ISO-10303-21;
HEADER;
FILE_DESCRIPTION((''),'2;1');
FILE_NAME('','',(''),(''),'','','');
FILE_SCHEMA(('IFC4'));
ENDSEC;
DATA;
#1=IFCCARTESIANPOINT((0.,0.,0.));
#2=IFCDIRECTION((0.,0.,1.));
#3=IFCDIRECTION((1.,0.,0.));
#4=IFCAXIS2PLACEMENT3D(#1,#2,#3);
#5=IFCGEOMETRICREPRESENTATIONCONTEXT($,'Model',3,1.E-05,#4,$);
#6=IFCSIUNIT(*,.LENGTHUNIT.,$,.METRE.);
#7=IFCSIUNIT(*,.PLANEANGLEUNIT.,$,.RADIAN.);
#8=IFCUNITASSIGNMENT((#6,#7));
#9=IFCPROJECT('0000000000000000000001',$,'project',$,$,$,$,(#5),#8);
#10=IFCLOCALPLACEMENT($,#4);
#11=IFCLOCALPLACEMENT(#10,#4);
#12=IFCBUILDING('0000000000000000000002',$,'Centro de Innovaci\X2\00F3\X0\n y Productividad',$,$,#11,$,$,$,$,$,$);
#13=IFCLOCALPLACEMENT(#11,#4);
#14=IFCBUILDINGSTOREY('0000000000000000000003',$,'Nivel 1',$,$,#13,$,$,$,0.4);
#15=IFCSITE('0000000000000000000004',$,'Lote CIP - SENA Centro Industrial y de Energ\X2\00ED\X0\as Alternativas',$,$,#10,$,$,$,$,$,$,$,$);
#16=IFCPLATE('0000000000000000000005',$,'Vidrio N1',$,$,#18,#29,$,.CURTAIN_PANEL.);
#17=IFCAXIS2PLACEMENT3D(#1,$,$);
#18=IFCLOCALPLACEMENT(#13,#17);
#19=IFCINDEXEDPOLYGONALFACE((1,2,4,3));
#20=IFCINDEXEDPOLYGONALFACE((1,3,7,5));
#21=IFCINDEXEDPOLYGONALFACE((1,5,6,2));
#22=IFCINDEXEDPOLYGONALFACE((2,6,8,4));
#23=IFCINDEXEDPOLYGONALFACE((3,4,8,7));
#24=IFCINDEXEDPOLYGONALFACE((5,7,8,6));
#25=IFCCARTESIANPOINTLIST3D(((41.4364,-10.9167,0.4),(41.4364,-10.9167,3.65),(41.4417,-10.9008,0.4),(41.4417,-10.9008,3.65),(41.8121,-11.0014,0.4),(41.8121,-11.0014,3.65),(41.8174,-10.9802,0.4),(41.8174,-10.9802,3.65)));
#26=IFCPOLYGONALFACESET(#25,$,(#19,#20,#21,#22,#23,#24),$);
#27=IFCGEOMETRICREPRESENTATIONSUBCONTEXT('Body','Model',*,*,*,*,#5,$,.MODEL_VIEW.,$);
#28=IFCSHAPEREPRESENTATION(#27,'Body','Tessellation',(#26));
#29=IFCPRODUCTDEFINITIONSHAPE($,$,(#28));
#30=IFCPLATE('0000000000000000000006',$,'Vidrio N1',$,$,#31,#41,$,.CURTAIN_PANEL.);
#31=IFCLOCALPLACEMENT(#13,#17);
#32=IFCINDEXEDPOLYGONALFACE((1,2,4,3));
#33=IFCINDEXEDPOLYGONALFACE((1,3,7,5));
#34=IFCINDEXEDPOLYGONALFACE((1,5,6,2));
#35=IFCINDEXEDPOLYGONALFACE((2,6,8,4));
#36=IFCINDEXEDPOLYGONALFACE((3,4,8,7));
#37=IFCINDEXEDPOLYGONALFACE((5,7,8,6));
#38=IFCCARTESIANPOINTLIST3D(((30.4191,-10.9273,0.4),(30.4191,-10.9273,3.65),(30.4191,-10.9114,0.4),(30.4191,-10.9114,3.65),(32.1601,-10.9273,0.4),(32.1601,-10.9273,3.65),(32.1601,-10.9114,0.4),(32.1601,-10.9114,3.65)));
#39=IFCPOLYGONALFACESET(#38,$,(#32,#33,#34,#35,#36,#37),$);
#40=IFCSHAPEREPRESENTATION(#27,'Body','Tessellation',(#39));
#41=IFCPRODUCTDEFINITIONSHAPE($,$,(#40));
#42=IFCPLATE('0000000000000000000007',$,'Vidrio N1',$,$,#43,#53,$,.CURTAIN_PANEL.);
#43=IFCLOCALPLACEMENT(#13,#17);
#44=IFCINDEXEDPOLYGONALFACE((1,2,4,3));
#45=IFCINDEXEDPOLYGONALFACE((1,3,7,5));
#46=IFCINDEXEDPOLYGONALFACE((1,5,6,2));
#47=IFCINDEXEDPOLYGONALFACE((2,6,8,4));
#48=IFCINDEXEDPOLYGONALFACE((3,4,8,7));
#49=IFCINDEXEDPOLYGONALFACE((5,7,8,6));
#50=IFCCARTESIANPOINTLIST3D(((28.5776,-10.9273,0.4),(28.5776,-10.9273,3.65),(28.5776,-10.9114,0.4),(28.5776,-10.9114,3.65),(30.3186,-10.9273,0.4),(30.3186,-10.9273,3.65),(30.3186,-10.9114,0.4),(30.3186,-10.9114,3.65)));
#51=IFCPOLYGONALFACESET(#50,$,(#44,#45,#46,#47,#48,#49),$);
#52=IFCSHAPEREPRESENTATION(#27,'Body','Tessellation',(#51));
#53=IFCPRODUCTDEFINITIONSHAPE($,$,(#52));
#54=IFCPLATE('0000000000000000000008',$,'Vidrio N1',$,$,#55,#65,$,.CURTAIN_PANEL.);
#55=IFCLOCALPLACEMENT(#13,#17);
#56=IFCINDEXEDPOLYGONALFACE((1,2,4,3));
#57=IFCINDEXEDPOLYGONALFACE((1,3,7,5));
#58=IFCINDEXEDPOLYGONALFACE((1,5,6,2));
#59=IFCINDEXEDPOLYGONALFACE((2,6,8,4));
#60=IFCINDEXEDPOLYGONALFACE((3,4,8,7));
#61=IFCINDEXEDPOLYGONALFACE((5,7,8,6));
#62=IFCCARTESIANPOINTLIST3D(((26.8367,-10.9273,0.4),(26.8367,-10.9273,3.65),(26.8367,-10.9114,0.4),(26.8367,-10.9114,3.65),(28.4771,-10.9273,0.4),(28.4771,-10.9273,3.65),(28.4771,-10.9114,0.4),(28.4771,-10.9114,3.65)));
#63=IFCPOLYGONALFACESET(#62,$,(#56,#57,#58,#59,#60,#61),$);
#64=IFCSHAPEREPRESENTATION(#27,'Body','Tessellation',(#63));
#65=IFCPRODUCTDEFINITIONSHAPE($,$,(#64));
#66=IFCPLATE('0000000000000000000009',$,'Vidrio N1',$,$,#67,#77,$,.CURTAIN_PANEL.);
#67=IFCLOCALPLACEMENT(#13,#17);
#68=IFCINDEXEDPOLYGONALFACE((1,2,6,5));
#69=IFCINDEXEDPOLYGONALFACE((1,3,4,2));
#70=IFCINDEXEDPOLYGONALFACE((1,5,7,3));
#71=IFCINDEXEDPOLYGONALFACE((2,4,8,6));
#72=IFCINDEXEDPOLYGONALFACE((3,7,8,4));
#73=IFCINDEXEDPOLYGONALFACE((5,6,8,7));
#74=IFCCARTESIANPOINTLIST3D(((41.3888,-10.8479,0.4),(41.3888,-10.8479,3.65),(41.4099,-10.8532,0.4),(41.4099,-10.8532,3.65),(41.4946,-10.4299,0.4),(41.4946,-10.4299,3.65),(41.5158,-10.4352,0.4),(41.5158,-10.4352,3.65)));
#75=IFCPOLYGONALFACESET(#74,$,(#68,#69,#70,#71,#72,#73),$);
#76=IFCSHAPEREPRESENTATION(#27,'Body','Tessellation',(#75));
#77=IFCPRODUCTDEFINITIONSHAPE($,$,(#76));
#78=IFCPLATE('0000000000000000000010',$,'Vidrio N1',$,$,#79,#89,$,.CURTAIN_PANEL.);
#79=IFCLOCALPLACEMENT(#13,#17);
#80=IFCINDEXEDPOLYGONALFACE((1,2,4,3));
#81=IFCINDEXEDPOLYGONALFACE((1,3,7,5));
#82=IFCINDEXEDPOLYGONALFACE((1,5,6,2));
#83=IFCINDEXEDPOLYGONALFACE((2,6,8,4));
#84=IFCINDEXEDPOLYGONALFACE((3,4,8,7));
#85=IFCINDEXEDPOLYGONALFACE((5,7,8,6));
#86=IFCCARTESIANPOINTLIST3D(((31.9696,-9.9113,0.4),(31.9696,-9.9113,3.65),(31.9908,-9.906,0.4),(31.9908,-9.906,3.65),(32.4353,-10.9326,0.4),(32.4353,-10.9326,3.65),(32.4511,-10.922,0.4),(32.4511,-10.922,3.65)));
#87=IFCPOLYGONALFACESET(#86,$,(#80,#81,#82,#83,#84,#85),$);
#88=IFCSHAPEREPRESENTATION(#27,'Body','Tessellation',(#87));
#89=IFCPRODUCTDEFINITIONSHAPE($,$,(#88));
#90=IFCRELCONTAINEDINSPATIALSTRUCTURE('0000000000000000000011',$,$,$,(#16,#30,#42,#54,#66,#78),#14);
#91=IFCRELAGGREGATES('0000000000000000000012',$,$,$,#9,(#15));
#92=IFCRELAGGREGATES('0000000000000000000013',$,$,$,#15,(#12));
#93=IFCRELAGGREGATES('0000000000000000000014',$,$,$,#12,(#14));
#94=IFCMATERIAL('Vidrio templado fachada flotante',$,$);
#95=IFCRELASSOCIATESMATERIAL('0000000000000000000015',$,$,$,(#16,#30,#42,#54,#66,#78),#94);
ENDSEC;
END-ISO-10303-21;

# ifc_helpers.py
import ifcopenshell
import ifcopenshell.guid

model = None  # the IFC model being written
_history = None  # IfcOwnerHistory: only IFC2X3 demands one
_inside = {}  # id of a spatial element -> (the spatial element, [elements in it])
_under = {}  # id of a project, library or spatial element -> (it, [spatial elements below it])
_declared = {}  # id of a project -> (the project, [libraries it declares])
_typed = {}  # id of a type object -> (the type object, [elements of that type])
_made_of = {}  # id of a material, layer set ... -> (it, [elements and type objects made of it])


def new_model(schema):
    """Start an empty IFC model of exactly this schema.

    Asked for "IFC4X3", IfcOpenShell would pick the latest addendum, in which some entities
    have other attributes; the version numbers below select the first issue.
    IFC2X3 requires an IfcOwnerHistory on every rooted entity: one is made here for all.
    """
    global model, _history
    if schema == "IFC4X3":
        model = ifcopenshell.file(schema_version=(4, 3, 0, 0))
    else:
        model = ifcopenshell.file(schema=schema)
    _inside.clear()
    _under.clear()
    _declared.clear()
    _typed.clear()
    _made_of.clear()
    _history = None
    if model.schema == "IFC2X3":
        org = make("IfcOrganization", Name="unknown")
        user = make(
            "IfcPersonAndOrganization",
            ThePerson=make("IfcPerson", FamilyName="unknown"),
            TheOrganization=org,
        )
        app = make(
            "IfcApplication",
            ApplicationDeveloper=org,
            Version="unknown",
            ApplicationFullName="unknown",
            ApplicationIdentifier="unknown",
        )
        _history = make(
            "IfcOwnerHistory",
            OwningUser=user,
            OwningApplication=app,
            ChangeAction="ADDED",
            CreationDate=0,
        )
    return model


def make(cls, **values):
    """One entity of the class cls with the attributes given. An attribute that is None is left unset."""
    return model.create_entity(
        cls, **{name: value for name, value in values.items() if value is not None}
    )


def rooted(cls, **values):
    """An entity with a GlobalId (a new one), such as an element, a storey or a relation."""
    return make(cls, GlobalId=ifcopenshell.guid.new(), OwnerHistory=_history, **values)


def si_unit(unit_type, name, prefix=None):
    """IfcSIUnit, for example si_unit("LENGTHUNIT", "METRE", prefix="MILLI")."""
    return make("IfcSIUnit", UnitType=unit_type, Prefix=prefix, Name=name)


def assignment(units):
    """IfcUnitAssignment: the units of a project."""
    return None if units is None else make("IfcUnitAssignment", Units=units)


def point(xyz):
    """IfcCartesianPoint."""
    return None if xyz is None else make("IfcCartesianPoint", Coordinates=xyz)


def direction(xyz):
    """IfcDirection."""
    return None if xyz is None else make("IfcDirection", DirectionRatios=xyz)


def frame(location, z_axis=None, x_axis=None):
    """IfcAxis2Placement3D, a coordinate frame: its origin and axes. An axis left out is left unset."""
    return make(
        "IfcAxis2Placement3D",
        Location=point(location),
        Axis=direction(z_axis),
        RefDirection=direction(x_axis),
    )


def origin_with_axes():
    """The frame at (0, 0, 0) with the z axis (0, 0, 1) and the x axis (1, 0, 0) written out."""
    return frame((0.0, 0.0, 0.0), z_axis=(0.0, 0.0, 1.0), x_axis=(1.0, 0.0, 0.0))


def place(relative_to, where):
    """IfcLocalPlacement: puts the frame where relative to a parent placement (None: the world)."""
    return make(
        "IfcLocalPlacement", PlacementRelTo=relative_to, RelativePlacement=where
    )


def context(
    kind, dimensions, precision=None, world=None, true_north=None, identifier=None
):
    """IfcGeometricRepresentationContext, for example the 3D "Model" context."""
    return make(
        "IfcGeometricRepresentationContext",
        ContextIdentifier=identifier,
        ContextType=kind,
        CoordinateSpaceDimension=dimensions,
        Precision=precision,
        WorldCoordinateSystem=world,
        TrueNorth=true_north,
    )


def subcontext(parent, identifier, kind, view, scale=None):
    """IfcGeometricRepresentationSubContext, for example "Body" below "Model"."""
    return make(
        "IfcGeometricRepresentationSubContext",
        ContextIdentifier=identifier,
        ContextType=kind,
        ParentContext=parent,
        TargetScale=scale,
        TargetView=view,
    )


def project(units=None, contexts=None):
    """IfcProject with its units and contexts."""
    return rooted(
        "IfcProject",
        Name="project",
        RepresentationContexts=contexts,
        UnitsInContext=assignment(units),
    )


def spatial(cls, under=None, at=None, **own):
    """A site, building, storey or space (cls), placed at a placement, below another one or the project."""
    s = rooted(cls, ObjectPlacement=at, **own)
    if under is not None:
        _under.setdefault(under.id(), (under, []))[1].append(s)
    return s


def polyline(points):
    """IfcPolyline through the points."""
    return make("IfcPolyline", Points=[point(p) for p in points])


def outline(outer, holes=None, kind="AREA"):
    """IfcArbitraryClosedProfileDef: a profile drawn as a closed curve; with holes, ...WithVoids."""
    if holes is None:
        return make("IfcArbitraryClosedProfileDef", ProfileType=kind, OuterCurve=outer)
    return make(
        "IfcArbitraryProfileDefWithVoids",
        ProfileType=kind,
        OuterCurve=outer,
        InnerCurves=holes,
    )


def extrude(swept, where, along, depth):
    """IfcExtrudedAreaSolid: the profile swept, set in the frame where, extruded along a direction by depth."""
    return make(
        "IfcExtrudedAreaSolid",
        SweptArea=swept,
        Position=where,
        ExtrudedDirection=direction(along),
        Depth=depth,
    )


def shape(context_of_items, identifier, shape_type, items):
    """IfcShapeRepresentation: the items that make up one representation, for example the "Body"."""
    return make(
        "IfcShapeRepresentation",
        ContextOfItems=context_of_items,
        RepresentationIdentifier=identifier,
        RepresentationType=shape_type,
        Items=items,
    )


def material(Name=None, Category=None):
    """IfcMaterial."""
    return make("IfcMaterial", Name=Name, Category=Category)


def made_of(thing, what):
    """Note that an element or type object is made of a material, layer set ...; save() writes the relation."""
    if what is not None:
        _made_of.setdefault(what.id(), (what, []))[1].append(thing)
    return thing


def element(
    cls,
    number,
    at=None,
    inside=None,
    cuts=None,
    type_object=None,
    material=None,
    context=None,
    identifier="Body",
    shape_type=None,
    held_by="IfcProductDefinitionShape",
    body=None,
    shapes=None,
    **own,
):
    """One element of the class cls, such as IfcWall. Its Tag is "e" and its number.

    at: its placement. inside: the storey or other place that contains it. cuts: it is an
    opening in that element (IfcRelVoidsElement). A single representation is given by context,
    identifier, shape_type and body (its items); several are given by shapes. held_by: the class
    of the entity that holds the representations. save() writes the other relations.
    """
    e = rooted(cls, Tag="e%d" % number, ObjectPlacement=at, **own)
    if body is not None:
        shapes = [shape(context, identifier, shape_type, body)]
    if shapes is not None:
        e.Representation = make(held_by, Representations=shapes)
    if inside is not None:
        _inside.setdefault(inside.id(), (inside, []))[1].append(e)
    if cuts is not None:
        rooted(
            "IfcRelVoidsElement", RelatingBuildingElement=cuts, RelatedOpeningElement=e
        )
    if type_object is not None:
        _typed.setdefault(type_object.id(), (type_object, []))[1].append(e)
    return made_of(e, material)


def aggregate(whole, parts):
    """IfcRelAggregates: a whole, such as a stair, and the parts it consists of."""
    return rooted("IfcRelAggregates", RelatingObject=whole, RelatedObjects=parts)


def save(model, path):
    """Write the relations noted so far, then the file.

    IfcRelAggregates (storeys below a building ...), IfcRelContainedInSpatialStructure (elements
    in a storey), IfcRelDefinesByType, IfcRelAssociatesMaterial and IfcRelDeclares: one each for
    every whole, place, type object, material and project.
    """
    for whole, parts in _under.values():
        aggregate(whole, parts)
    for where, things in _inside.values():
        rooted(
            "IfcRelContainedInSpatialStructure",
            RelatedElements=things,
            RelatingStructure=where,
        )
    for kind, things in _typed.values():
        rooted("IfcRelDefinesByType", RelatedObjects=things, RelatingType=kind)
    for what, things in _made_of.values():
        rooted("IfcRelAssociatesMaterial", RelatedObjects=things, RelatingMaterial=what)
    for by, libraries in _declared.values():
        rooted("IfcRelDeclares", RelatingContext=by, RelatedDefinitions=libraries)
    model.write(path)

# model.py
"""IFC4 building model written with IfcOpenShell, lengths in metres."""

from ifc_helpers import new_model, si_unit, frame, origin_with_axes, place, context, subcontext, project, spatial, polyline, outline, extrude, material, element, save


model = new_model("IFC4")

# Units and contexts
model_context = context("Model", 3, precision=1e-05, world=origin_with_axes())
body_context = subcontext(model_context, "Body", "Model", "MODEL_VIEW")
ifc_project = project(units=[si_unit("LENGTHUNIT", "METRE"), si_unit("PLANEANGLEUNIT", "RADIAN")], contexts=[model_context])

# Site, building, storey
site_placement = place(None, origin_with_axes())
site = spatial("IfcSite", under=ifc_project, at=site_placement, Name="Lote CIP - SENA Centro Industrial y de Energías Alternativas")
building_placement = place(site_placement, origin_with_axes())
building = spatial("IfcBuilding", under=site, at=building_placement, Name="Centro de Innovación y Productividad")
storey_placement = place(building_placement, origin_with_axes())
storey = spatial("IfcBuildingStorey", under=building, at=storey_placement, Name="Nivel 1", Elevation=0.4)

# Plates
ifc_material = material(Name="Vidrio templado fachada flotante")
plate_1_placement = place(storey_placement, origin_with_axes())
element("IfcPlate", 1, at=plate_1_placement, inside=storey, material=ifc_material, Name="Vidrio N1", PredefinedType="CURTAIN_PANEL", context=body_context, shape_type="SweptSolid", body=[
    extrude(outline(polyline([(41.4364, -10.9167), (41.4417, -10.9008), (41.8174, -10.9802), (41.8121, -11.0014), (41.4364, -10.9167)])), frame((0.0, 0.0, 0.4)), (0.0, 0.0, 1.0), 3.25),
])
plate_2_placement = place(storey_placement, origin_with_axes())
element("IfcPlate", 2, at=plate_2_placement, inside=storey, material=ifc_material, Name="Vidrio N1", PredefinedType="CURTAIN_PANEL", context=body_context, shape_type="SweptSolid", body=[
    extrude(outline(polyline([(32.1601, -10.9114), (32.1601, -10.9273), (30.4191, -10.9273), (30.4191, -10.9114), (32.1601, -10.9114)])), frame((0.0, 0.0, 0.4)), (0.0, 0.0, 1.0), 3.25),
])
plate_3_placement = place(storey_placement, origin_with_axes())
element("IfcPlate", 3, at=plate_3_placement, inside=storey, material=ifc_material, Name="Vidrio N1", PredefinedType="CURTAIN_PANEL", context=body_context, shape_type="SweptSolid", body=[
    extrude(outline(polyline([(28.5776, -10.9273), (28.5776, -10.9114), (30.3186, -10.9114), (30.3186, -10.9273), (28.5776, -10.9273)])), frame((0.0, 0.0, 0.4)), (0.0, 0.0, 1.0), 3.25),
])
plate_4_placement = place(storey_placement, origin_with_axes())
element("IfcPlate", 4, at=plate_4_placement, inside=storey, material=ifc_material, Name="Vidrio N1", PredefinedType="CURTAIN_PANEL", context=body_context, shape_type="SweptSolid", body=[
    extrude(outline(polyline([(28.4771, -10.9114), (28.4771, -10.9273), (26.8367, -10.9273), (26.8367, -10.9114), (28.4771, -10.9114)])), frame((0.0, 0.0, 0.4)), (0.0, 0.0, 1.0), 3.25),
])
plate_5_placement = place(storey_placement, origin_with_axes())
element("IfcPlate", 5, at=plate_5_placement, inside=storey, material=ifc_material, Name="Vidrio N1", PredefinedType="CURTAIN_PANEL", context=body_context, shape_type="SweptSolid", body=[
    extrude(outline(polyline([(41.4099, -10.8532), (41.3888, -10.8479), (41.4946, -10.4299), (41.5158, -10.4352), (41.4099, -10.8532)])), frame((0.0, 0.0, 0.4)), (0.0, 0.0, 1.0), 3.25),
])
plate_6_placement = place(storey_placement, origin_with_axes())
element("IfcPlate", 6, at=plate_6_placement, inside=storey, material=ifc_material, Name="Vidrio N1", PredefinedType="CURTAIN_PANEL", context=body_context, shape_type="SweptSolid", body=[
    extrude(outline(polyline([(32.4511, -10.922), (32.4353, -10.9326), (31.9696, -9.9113), (31.9908, -9.906), (32.4511, -10.922)])), frame((0.0, 0.0, 0.4)), (0.0, 0.0, 1.0), 3.25),
])

save(model, "model.ifc")
